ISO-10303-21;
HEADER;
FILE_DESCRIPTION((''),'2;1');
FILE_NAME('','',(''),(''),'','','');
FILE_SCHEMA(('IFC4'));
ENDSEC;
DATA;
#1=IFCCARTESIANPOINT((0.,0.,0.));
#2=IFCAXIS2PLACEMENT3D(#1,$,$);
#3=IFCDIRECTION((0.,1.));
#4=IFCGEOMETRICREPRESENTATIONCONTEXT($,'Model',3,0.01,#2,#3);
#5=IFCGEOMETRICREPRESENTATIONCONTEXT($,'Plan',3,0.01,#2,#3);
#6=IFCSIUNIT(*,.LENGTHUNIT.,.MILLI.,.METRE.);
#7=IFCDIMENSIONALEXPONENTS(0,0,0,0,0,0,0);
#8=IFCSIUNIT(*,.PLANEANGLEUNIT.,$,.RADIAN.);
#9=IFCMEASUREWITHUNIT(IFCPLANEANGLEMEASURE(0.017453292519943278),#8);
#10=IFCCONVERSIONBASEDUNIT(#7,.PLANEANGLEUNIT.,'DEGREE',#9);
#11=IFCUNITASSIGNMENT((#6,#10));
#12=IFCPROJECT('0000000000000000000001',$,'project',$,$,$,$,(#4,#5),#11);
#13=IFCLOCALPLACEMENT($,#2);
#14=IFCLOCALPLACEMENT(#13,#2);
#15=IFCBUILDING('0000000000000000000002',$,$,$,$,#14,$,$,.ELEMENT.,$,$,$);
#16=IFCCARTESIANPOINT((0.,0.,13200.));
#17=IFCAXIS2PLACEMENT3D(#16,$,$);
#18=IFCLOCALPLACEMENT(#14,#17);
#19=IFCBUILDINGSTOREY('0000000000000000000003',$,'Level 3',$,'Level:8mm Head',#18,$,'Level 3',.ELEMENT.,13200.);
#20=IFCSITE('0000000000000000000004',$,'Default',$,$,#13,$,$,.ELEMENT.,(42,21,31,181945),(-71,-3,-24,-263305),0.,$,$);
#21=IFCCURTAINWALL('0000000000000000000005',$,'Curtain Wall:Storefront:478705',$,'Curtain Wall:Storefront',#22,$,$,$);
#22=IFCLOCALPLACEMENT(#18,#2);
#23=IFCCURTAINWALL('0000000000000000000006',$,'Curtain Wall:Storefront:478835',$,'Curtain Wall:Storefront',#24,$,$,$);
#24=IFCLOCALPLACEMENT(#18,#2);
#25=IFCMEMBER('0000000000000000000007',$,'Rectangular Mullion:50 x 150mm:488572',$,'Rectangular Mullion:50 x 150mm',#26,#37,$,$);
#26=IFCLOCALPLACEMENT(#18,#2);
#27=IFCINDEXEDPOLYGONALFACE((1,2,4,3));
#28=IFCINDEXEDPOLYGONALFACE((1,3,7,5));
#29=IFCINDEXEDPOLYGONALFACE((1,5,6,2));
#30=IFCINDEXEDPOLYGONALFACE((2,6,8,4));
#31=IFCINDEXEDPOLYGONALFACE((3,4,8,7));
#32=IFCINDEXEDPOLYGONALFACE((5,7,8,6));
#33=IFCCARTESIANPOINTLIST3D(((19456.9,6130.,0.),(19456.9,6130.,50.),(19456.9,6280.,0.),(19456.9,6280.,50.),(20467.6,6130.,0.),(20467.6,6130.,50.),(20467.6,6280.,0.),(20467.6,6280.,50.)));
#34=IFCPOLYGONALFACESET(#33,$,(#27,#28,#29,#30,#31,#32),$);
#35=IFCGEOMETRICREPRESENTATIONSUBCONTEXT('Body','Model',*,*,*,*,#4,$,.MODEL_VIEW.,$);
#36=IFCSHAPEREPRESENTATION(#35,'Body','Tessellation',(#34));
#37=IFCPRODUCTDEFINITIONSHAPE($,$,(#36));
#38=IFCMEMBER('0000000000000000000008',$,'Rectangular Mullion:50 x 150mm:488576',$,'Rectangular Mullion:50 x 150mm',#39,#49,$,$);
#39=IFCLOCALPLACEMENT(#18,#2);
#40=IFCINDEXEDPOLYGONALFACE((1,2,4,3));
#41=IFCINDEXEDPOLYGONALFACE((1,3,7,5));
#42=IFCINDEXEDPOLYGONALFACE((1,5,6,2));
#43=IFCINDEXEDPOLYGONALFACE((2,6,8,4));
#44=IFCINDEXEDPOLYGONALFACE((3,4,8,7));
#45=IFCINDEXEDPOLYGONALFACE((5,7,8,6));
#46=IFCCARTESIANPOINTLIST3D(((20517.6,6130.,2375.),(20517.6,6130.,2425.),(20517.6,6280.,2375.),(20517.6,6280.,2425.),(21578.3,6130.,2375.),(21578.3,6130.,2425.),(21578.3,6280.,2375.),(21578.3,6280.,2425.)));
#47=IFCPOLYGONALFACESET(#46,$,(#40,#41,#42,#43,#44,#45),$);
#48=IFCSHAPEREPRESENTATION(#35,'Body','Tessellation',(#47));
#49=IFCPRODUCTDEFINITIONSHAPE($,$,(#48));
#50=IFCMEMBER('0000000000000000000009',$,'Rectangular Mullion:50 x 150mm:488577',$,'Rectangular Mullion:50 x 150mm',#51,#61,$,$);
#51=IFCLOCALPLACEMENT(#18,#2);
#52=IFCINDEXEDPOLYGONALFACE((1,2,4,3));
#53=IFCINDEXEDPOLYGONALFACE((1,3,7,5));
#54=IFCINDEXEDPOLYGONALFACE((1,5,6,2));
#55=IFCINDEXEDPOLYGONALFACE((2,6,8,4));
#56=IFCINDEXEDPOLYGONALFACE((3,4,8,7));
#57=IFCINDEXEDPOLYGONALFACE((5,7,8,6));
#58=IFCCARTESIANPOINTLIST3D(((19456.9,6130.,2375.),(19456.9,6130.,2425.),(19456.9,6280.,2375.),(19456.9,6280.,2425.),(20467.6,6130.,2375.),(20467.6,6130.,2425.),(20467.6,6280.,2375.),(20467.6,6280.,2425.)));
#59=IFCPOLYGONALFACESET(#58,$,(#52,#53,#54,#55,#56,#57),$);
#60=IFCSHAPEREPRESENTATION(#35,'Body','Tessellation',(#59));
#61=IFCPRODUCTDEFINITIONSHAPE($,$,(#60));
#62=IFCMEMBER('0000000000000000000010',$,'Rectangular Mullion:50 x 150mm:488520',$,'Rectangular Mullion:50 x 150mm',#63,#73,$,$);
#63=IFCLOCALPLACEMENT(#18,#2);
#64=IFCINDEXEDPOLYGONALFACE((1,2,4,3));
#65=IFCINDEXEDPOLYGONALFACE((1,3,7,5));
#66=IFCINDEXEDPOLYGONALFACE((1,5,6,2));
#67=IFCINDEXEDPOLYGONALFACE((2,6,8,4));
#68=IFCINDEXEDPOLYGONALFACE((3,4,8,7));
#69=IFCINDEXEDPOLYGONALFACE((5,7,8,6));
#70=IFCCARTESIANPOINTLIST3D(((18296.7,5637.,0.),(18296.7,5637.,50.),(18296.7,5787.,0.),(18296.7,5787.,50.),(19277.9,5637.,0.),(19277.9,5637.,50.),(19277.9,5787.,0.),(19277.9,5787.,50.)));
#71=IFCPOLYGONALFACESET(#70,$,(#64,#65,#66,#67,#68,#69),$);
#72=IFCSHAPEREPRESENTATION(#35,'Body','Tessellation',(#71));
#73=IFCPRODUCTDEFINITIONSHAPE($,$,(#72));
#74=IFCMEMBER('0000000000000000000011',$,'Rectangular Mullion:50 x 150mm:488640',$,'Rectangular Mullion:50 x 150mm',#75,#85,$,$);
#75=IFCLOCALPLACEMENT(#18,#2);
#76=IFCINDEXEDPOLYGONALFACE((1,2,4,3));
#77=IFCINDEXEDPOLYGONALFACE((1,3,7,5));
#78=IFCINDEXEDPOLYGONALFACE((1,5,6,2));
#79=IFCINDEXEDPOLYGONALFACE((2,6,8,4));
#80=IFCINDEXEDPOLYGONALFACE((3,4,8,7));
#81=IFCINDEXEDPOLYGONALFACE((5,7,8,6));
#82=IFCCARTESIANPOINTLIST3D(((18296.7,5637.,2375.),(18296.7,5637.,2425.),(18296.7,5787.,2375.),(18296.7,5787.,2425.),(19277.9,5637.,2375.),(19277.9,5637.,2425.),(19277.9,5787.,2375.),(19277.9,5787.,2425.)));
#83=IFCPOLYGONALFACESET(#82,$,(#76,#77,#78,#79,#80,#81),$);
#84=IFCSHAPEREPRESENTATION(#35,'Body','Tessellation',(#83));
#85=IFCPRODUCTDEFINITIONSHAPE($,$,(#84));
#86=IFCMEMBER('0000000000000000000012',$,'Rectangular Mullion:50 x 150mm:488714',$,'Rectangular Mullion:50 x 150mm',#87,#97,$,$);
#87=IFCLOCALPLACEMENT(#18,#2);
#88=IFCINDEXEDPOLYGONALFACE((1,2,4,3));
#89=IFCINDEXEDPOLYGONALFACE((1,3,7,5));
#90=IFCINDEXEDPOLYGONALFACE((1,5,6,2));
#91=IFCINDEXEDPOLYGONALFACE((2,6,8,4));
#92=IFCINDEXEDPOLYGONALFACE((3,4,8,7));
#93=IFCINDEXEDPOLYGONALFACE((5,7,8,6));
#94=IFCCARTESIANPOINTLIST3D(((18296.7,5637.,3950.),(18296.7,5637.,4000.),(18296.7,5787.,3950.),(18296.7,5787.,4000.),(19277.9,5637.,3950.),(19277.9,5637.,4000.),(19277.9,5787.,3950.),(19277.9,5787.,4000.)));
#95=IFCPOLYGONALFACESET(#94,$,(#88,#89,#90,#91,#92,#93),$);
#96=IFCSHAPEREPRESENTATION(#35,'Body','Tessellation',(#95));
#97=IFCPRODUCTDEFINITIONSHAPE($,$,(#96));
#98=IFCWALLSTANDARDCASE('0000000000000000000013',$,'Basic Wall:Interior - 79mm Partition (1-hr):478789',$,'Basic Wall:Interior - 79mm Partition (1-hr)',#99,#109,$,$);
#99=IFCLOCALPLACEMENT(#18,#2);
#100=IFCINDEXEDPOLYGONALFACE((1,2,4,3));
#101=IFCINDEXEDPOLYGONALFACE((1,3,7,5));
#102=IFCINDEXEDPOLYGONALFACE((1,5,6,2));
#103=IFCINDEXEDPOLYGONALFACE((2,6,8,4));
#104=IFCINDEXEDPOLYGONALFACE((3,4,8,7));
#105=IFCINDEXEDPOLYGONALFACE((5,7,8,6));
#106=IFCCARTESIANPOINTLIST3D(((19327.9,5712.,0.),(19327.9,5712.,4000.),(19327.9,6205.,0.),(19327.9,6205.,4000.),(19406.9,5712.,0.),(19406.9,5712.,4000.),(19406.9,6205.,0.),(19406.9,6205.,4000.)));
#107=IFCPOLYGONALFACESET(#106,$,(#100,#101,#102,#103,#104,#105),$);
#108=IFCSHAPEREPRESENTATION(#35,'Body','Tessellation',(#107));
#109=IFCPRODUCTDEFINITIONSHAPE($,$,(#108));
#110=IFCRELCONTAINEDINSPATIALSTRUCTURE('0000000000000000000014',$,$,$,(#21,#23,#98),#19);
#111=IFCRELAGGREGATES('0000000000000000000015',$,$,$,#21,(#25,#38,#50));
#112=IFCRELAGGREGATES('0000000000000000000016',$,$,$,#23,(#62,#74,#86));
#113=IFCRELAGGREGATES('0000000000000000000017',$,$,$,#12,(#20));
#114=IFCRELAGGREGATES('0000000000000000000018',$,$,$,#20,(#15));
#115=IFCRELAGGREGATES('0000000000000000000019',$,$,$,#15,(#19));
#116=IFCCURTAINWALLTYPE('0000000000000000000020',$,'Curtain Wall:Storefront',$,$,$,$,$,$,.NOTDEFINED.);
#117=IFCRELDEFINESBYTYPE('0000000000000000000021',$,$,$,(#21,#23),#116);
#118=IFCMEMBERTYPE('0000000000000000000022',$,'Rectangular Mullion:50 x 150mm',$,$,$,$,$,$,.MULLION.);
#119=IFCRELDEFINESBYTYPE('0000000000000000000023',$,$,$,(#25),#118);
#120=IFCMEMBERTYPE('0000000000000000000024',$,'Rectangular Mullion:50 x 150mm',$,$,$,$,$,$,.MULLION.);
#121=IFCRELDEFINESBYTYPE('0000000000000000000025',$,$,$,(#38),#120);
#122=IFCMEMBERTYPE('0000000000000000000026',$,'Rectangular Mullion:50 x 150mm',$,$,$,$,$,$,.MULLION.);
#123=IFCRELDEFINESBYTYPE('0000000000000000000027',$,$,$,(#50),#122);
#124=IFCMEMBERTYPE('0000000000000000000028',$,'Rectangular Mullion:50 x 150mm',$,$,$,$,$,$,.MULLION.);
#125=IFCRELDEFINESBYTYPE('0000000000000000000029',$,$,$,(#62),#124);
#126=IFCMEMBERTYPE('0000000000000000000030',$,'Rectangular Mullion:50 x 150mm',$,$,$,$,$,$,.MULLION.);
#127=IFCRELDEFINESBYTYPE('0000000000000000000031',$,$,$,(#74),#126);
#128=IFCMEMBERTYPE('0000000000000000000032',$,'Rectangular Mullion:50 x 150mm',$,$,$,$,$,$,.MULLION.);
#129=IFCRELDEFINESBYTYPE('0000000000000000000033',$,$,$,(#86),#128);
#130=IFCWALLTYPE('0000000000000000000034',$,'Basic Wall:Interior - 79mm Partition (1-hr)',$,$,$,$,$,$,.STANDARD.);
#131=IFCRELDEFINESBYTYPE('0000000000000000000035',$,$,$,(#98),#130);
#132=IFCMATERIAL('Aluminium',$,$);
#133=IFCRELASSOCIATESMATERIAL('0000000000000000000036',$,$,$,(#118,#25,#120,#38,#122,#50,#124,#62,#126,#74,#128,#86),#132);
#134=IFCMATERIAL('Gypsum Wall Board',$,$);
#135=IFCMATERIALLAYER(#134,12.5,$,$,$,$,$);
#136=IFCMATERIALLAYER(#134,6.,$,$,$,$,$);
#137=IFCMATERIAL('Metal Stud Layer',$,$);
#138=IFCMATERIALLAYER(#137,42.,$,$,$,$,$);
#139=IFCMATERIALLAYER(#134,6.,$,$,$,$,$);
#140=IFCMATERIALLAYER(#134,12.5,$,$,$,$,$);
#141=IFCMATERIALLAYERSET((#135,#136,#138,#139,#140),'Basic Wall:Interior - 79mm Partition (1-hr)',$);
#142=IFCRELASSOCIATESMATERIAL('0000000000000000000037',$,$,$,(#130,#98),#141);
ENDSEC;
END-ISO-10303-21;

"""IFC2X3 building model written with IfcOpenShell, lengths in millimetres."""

from ifc_helpers import new_model, entity, si_unit, converted_unit, direction, frame, frame_2d, origin, origin_2d_with_axis, place, context, subcontext, project, spatial, rectangle, extrude, source, transform, mapped, material, layer, layer_set, layer_usage, type_object, type_shapes, element, aggregate, save


model = new_model("IFC2X3")

# Units and contexts
model_context = context("Model", 3, precision=0.01, world=origin(), true_north=direction((0.0, 1.0)))
plan_context = context("Plan", 3, precision=0.01, world=origin(), true_north=direction((0.0, 1.0)))
body_context = subcontext(model_context, "Body", "Model", "MODEL_VIEW")
ifc_project = project(units=[si_unit("LENGTHUNIT", "METRE", prefix="MILLI"), converted_unit("PLANEANGLEUNIT", "DEGREE", entity("IfcPlaneAngleMeasure", 0.017453292519943278), si_unit("PLANEANGLEUNIT", "RADIAN"), dimensions=[0, 0, 0, 0, 0, 0, 0])], contexts=[model_context, plan_context])

# Site, building, storey
site_placement = place(None, origin())
site = spatial("IfcSite", under=ifc_project, at=site_placement, Name="Default", CompositionType="ELEMENT", RefLatitude=(42, 21, 31, 181945), RefLongitude=(-71, -3, -24, -263305), RefElevation=0.0)
building_placement = place(site_placement, origin())
building = spatial("IfcBuilding", under=site, at=building_placement, CompositionType="ELEMENT")
storey_placement = place(building_placement, frame((0.0, 0.0, 13200.0)))
storey = spatial("IfcBuildingStorey", under=building, at=storey_placement, Name="Level 3", ObjectType="Level:8mm Head", LongName="Level 3", CompositionType="ELEMENT", Elevation=13200.0)

# Curtain walls
curtain_wall_type = type_object("IfcCurtainWallType", Name="Curtain Wall:Storefront", PredefinedType="NOTDEFINED")
curtain_wall_1_placement = place(storey_placement, frame((0.0, 0.0, -13200.0)))
curtain_wall_1 = element("IfcCurtainWall", 1, at=curtain_wall_1_placement, inside=storey, type_object=curtain_wall_type, Name="Curtain Wall:Storefront:478705", ObjectType="Curtain Wall:Storefront")
ifc_material_1 = material(Name="Aluminium")
curtain_wall_2_placement = place(storey_placement, frame((0.0, 0.0, -13200.0)))
curtain_wall_2 = element("IfcCurtainWall", 2, at=curtain_wall_2_placement, inside=storey, type_object=curtain_wall_type, Name="Curtain Wall:Storefront:478835", ObjectType="Curtain Wall:Storefront")

# Members
member_type_1 = type_object("IfcMemberType", Name="Rectangular Mullion:50 x 150mm", PredefinedType="MULLION", material=ifc_material_1)
shared_shape_1 = source(origin(), body_context, "Body", "SweptSolid", [
    extrude(rectangle(XDim=50.0, YDim=150.0, at=origin_2d_with_axis()), frame((-25.0, 0.0, -1010.7), z_axis=(0.0, 0.0, 1.0), x_axis=(-1.0, 0.0, 0.0)), (0.0, 0.0, 1.0), 1010.7),
])
type_shapes(member_type_1, [shared_shape_1])
member_1_placement = place(curtain_wall_1_placement, frame((20467.6, 6205.0, 13200.0), z_axis=(1.0, 0.0, 0.0), x_axis=(0.0, 0.0, -1.0)))
member_1 = element("IfcMember", 3, at=member_1_placement, type_object=member_type_1, material=ifc_material_1, Name="Rectangular Mullion:50 x 150mm:488572", ObjectType="Rectangular Mullion:50 x 150mm", context=body_context, shape_type="MappedRepresentation", body=[
    mapped(shared_shape_1, transform((0.0, 0.0, 0.0), scale=1.0)),
])
member_type_2 = type_object("IfcMemberType", Name="Rectangular Mullion:50 x 150mm", PredefinedType="MULLION", material=ifc_material_1)
shared_shape_2 = source(origin(), body_context, "Body", "SweptSolid", [
    extrude(rectangle(XDim=50.0, YDim=150.0, at=origin_2d_with_axis()), frame((0.0, 0.0, -1060.7), z_axis=(0.0, 0.0, 1.0), x_axis=(-1.0, 0.0, 0.0)), (0.0, 0.0, 1.0), 1060.7),
])
type_shapes(member_type_2, [shared_shape_2])
member_2_placement = place(curtain_wall_1_placement, frame((20517.6, 6205.0, 15600.0), z_axis=(-1.0, 0.0, 0.0), x_axis=(0.0, 0.0, 1.0)))
member_2 = element("IfcMember", 4, at=member_2_placement, type_object=member_type_2, material=ifc_material_1, Name="Rectangular Mullion:50 x 150mm:488576", ObjectType="Rectangular Mullion:50 x 150mm", context=body_context, shape_type="MappedRepresentation", body=[
    mapped(shared_shape_2, transform((0.0, 0.0, 0.0), scale=1.0)),
])
member_type_3 = type_object("IfcMemberType", Name="Rectangular Mullion:50 x 150mm", PredefinedType="MULLION", material=ifc_material_1)
shared_shape_3 = source(origin(), body_context, "Body", "SweptSolid", [
    extrude(rectangle(XDim=50.0, YDim=150.0, at=origin_2d_with_axis()), frame((0.0, 0.0, -1010.7), z_axis=(0.0, 0.0, 1.0), x_axis=(-1.0, 0.0, 0.0)), (0.0, 0.0, 1.0), 1010.7),
])
type_shapes(member_type_3, [shared_shape_3])
member_3_placement = place(curtain_wall_1_placement, frame((19456.9, 6205.0, 15600.0), z_axis=(-1.0, 0.0, 0.0), x_axis=(0.0, 0.0, 1.0)))
member_3 = element("IfcMember", 5, at=member_3_placement, type_object=member_type_3, material=ifc_material_1, Name="Rectangular Mullion:50 x 150mm:488577", ObjectType="Rectangular Mullion:50 x 150mm", context=body_context, shape_type="MappedRepresentation", body=[
    mapped(shared_shape_3, transform((0.0, 0.0, 0.0), scale=1.0)),
])
member_type_4 = type_object("IfcMemberType", Name="Rectangular Mullion:50 x 150mm", PredefinedType="MULLION", material=ifc_material_1)
shared_shape_4 = source(origin(), body_context, "Body", "SweptSolid", [
    extrude(rectangle(XDim=50.0, YDim=150.0, at=origin_2d_with_axis()), frame((-25.0, 0.0, -981.3), z_axis=(0.0, 0.0, 1.0), x_axis=(-1.0, 0.0, 0.0)), (0.0, 0.0, 1.0), 981.3),
])
type_shapes(member_type_4, [shared_shape_4])
member_4_placement = place(curtain_wall_2_placement, frame((19277.9, 5712.0, 13200.0), z_axis=(1.0, 0.0, 0.0), x_axis=(0.0, 0.0, -1.0)))
member_4 = element("IfcMember", 6, at=member_4_placement, type_object=member_type_4, material=ifc_material_1, Name="Rectangular Mullion:50 x 150mm:488520", ObjectType="Rectangular Mullion:50 x 150mm", context=body_context, shape_type="MappedRepresentation", body=[
    mapped(shared_shape_4, transform((0.0, 0.0, 0.0), scale=1.0)),
])
member_type_5 = type_object("IfcMemberType", Name="Rectangular Mullion:50 x 150mm", PredefinedType="MULLION", material=ifc_material_1)
shared_shape_5 = source(origin(), body_context, "Body", "SweptSolid", [
    extrude(rectangle(XDim=50.0, YDim=150.0, at=origin_2d_with_axis()), frame((0.0, 0.0, -981.3), z_axis=(0.0, 0.0, 1.0), x_axis=(-1.0, 0.0, 0.0)), (0.0, 0.0, 1.0), 981.3),
])
type_shapes(member_type_5, [shared_shape_5])
member_5_placement = place(curtain_wall_2_placement, frame((18296.7, 5712.0, 15600.0), z_axis=(-1.0, 0.0, 0.0), x_axis=(0.0, 0.0, 1.0)))
member_5 = element("IfcMember", 7, at=member_5_placement, type_object=member_type_5, material=ifc_material_1, Name="Rectangular Mullion:50 x 150mm:488640", ObjectType="Rectangular Mullion:50 x 150mm", context=body_context, shape_type="MappedRepresentation", body=[
    mapped(shared_shape_5, transform((0.0, 0.0, 0.0), scale=1.0)),
])
member_type_6 = type_object("IfcMemberType", Name="Rectangular Mullion:50 x 150mm", PredefinedType="MULLION", material=ifc_material_1)
shared_shape_6 = source(origin(), body_context, "Body", "SweptSolid", [
    extrude(rectangle(XDim=50.0, YDim=150.0, at=origin_2d_with_axis()), frame((-25.0, 0.0, -981.3), z_axis=(0.0, 0.0, 1.0), x_axis=(-1.0, 0.0, 0.0)), (0.0, 0.0, 1.0), 981.3),
])
type_shapes(member_type_6, [shared_shape_6])
member_6_placement = place(curtain_wall_2_placement, frame((18296.7, 5712.0, 17200.0), z_axis=(-1.0, 0.0, 0.0), x_axis=(0.0, 0.0, 1.0)))
member_6 = element("IfcMember", 8, at=member_6_placement, type_object=member_type_6, material=ifc_material_1, Name="Rectangular Mullion:50 x 150mm:488714", ObjectType="Rectangular Mullion:50 x 150mm", context=body_context, shape_type="MappedRepresentation", body=[
    mapped(shared_shape_6, transform((0.0, 0.0, 0.0), scale=1.0)),
])

aggregate(curtain_wall_1, [member_1, member_2, member_3])
aggregate(curtain_wall_2, [member_4, member_5, member_6])

# Wall
ifc_material_2 = material(Name="Gypsum Wall Board")
ifc_layer_1 = layer(ifc_material_2, 12.5)
ifc_layer_2 = layer(ifc_material_2, 6.0)
ifc_material_3 = material(Name="Metal Stud Layer")
ifc_layer_3 = layer(ifc_material_3, 42.0)
ifc_layer_4 = layer(ifc_material_2, 6.0)
ifc_layer_5 = layer(ifc_material_2, 12.5)
ifc_layer_set = layer_set([ifc_layer_1, ifc_layer_2, ifc_layer_3, ifc_layer_4, ifc_layer_5], Name="Basic Wall:Interior - 79mm Partition (1-hr)")
ifc_layer_usage = layer_usage(ifc_layer_set, "AXIS2", "NEGATIVE", 39.5)
wall_type = type_object("IfcWallType", Name="Basic Wall:Interior - 79mm Partition (1-hr)", PredefinedType="STANDARD", material=ifc_layer_set)
wall_placement = place(storey_placement, frame((19367.4, 6205.0, 0.0), z_axis=(0.0, 0.0, 1.0), x_axis=(0.0, -1.0, 0.0)))
element("IfcWallStandardCase", 9, at=wall_placement, inside=storey, type_object=wall_type, material=ifc_layer_usage, Name="Basic Wall:Interior - 79mm Partition (1-hr):478789", ObjectType="Basic Wall:Interior - 79mm Partition (1-hr)", context=body_context, shape_type="SweptSolid", body=[
    extrude(rectangle(XDim=493.0, YDim=79.0, at=frame_2d((246.5, 0.0), x_axis=(-1.0, 0.0))), origin(), (0.0, 0.0, 1.0), 4000.0),
])

save(model, "model.ifc")
